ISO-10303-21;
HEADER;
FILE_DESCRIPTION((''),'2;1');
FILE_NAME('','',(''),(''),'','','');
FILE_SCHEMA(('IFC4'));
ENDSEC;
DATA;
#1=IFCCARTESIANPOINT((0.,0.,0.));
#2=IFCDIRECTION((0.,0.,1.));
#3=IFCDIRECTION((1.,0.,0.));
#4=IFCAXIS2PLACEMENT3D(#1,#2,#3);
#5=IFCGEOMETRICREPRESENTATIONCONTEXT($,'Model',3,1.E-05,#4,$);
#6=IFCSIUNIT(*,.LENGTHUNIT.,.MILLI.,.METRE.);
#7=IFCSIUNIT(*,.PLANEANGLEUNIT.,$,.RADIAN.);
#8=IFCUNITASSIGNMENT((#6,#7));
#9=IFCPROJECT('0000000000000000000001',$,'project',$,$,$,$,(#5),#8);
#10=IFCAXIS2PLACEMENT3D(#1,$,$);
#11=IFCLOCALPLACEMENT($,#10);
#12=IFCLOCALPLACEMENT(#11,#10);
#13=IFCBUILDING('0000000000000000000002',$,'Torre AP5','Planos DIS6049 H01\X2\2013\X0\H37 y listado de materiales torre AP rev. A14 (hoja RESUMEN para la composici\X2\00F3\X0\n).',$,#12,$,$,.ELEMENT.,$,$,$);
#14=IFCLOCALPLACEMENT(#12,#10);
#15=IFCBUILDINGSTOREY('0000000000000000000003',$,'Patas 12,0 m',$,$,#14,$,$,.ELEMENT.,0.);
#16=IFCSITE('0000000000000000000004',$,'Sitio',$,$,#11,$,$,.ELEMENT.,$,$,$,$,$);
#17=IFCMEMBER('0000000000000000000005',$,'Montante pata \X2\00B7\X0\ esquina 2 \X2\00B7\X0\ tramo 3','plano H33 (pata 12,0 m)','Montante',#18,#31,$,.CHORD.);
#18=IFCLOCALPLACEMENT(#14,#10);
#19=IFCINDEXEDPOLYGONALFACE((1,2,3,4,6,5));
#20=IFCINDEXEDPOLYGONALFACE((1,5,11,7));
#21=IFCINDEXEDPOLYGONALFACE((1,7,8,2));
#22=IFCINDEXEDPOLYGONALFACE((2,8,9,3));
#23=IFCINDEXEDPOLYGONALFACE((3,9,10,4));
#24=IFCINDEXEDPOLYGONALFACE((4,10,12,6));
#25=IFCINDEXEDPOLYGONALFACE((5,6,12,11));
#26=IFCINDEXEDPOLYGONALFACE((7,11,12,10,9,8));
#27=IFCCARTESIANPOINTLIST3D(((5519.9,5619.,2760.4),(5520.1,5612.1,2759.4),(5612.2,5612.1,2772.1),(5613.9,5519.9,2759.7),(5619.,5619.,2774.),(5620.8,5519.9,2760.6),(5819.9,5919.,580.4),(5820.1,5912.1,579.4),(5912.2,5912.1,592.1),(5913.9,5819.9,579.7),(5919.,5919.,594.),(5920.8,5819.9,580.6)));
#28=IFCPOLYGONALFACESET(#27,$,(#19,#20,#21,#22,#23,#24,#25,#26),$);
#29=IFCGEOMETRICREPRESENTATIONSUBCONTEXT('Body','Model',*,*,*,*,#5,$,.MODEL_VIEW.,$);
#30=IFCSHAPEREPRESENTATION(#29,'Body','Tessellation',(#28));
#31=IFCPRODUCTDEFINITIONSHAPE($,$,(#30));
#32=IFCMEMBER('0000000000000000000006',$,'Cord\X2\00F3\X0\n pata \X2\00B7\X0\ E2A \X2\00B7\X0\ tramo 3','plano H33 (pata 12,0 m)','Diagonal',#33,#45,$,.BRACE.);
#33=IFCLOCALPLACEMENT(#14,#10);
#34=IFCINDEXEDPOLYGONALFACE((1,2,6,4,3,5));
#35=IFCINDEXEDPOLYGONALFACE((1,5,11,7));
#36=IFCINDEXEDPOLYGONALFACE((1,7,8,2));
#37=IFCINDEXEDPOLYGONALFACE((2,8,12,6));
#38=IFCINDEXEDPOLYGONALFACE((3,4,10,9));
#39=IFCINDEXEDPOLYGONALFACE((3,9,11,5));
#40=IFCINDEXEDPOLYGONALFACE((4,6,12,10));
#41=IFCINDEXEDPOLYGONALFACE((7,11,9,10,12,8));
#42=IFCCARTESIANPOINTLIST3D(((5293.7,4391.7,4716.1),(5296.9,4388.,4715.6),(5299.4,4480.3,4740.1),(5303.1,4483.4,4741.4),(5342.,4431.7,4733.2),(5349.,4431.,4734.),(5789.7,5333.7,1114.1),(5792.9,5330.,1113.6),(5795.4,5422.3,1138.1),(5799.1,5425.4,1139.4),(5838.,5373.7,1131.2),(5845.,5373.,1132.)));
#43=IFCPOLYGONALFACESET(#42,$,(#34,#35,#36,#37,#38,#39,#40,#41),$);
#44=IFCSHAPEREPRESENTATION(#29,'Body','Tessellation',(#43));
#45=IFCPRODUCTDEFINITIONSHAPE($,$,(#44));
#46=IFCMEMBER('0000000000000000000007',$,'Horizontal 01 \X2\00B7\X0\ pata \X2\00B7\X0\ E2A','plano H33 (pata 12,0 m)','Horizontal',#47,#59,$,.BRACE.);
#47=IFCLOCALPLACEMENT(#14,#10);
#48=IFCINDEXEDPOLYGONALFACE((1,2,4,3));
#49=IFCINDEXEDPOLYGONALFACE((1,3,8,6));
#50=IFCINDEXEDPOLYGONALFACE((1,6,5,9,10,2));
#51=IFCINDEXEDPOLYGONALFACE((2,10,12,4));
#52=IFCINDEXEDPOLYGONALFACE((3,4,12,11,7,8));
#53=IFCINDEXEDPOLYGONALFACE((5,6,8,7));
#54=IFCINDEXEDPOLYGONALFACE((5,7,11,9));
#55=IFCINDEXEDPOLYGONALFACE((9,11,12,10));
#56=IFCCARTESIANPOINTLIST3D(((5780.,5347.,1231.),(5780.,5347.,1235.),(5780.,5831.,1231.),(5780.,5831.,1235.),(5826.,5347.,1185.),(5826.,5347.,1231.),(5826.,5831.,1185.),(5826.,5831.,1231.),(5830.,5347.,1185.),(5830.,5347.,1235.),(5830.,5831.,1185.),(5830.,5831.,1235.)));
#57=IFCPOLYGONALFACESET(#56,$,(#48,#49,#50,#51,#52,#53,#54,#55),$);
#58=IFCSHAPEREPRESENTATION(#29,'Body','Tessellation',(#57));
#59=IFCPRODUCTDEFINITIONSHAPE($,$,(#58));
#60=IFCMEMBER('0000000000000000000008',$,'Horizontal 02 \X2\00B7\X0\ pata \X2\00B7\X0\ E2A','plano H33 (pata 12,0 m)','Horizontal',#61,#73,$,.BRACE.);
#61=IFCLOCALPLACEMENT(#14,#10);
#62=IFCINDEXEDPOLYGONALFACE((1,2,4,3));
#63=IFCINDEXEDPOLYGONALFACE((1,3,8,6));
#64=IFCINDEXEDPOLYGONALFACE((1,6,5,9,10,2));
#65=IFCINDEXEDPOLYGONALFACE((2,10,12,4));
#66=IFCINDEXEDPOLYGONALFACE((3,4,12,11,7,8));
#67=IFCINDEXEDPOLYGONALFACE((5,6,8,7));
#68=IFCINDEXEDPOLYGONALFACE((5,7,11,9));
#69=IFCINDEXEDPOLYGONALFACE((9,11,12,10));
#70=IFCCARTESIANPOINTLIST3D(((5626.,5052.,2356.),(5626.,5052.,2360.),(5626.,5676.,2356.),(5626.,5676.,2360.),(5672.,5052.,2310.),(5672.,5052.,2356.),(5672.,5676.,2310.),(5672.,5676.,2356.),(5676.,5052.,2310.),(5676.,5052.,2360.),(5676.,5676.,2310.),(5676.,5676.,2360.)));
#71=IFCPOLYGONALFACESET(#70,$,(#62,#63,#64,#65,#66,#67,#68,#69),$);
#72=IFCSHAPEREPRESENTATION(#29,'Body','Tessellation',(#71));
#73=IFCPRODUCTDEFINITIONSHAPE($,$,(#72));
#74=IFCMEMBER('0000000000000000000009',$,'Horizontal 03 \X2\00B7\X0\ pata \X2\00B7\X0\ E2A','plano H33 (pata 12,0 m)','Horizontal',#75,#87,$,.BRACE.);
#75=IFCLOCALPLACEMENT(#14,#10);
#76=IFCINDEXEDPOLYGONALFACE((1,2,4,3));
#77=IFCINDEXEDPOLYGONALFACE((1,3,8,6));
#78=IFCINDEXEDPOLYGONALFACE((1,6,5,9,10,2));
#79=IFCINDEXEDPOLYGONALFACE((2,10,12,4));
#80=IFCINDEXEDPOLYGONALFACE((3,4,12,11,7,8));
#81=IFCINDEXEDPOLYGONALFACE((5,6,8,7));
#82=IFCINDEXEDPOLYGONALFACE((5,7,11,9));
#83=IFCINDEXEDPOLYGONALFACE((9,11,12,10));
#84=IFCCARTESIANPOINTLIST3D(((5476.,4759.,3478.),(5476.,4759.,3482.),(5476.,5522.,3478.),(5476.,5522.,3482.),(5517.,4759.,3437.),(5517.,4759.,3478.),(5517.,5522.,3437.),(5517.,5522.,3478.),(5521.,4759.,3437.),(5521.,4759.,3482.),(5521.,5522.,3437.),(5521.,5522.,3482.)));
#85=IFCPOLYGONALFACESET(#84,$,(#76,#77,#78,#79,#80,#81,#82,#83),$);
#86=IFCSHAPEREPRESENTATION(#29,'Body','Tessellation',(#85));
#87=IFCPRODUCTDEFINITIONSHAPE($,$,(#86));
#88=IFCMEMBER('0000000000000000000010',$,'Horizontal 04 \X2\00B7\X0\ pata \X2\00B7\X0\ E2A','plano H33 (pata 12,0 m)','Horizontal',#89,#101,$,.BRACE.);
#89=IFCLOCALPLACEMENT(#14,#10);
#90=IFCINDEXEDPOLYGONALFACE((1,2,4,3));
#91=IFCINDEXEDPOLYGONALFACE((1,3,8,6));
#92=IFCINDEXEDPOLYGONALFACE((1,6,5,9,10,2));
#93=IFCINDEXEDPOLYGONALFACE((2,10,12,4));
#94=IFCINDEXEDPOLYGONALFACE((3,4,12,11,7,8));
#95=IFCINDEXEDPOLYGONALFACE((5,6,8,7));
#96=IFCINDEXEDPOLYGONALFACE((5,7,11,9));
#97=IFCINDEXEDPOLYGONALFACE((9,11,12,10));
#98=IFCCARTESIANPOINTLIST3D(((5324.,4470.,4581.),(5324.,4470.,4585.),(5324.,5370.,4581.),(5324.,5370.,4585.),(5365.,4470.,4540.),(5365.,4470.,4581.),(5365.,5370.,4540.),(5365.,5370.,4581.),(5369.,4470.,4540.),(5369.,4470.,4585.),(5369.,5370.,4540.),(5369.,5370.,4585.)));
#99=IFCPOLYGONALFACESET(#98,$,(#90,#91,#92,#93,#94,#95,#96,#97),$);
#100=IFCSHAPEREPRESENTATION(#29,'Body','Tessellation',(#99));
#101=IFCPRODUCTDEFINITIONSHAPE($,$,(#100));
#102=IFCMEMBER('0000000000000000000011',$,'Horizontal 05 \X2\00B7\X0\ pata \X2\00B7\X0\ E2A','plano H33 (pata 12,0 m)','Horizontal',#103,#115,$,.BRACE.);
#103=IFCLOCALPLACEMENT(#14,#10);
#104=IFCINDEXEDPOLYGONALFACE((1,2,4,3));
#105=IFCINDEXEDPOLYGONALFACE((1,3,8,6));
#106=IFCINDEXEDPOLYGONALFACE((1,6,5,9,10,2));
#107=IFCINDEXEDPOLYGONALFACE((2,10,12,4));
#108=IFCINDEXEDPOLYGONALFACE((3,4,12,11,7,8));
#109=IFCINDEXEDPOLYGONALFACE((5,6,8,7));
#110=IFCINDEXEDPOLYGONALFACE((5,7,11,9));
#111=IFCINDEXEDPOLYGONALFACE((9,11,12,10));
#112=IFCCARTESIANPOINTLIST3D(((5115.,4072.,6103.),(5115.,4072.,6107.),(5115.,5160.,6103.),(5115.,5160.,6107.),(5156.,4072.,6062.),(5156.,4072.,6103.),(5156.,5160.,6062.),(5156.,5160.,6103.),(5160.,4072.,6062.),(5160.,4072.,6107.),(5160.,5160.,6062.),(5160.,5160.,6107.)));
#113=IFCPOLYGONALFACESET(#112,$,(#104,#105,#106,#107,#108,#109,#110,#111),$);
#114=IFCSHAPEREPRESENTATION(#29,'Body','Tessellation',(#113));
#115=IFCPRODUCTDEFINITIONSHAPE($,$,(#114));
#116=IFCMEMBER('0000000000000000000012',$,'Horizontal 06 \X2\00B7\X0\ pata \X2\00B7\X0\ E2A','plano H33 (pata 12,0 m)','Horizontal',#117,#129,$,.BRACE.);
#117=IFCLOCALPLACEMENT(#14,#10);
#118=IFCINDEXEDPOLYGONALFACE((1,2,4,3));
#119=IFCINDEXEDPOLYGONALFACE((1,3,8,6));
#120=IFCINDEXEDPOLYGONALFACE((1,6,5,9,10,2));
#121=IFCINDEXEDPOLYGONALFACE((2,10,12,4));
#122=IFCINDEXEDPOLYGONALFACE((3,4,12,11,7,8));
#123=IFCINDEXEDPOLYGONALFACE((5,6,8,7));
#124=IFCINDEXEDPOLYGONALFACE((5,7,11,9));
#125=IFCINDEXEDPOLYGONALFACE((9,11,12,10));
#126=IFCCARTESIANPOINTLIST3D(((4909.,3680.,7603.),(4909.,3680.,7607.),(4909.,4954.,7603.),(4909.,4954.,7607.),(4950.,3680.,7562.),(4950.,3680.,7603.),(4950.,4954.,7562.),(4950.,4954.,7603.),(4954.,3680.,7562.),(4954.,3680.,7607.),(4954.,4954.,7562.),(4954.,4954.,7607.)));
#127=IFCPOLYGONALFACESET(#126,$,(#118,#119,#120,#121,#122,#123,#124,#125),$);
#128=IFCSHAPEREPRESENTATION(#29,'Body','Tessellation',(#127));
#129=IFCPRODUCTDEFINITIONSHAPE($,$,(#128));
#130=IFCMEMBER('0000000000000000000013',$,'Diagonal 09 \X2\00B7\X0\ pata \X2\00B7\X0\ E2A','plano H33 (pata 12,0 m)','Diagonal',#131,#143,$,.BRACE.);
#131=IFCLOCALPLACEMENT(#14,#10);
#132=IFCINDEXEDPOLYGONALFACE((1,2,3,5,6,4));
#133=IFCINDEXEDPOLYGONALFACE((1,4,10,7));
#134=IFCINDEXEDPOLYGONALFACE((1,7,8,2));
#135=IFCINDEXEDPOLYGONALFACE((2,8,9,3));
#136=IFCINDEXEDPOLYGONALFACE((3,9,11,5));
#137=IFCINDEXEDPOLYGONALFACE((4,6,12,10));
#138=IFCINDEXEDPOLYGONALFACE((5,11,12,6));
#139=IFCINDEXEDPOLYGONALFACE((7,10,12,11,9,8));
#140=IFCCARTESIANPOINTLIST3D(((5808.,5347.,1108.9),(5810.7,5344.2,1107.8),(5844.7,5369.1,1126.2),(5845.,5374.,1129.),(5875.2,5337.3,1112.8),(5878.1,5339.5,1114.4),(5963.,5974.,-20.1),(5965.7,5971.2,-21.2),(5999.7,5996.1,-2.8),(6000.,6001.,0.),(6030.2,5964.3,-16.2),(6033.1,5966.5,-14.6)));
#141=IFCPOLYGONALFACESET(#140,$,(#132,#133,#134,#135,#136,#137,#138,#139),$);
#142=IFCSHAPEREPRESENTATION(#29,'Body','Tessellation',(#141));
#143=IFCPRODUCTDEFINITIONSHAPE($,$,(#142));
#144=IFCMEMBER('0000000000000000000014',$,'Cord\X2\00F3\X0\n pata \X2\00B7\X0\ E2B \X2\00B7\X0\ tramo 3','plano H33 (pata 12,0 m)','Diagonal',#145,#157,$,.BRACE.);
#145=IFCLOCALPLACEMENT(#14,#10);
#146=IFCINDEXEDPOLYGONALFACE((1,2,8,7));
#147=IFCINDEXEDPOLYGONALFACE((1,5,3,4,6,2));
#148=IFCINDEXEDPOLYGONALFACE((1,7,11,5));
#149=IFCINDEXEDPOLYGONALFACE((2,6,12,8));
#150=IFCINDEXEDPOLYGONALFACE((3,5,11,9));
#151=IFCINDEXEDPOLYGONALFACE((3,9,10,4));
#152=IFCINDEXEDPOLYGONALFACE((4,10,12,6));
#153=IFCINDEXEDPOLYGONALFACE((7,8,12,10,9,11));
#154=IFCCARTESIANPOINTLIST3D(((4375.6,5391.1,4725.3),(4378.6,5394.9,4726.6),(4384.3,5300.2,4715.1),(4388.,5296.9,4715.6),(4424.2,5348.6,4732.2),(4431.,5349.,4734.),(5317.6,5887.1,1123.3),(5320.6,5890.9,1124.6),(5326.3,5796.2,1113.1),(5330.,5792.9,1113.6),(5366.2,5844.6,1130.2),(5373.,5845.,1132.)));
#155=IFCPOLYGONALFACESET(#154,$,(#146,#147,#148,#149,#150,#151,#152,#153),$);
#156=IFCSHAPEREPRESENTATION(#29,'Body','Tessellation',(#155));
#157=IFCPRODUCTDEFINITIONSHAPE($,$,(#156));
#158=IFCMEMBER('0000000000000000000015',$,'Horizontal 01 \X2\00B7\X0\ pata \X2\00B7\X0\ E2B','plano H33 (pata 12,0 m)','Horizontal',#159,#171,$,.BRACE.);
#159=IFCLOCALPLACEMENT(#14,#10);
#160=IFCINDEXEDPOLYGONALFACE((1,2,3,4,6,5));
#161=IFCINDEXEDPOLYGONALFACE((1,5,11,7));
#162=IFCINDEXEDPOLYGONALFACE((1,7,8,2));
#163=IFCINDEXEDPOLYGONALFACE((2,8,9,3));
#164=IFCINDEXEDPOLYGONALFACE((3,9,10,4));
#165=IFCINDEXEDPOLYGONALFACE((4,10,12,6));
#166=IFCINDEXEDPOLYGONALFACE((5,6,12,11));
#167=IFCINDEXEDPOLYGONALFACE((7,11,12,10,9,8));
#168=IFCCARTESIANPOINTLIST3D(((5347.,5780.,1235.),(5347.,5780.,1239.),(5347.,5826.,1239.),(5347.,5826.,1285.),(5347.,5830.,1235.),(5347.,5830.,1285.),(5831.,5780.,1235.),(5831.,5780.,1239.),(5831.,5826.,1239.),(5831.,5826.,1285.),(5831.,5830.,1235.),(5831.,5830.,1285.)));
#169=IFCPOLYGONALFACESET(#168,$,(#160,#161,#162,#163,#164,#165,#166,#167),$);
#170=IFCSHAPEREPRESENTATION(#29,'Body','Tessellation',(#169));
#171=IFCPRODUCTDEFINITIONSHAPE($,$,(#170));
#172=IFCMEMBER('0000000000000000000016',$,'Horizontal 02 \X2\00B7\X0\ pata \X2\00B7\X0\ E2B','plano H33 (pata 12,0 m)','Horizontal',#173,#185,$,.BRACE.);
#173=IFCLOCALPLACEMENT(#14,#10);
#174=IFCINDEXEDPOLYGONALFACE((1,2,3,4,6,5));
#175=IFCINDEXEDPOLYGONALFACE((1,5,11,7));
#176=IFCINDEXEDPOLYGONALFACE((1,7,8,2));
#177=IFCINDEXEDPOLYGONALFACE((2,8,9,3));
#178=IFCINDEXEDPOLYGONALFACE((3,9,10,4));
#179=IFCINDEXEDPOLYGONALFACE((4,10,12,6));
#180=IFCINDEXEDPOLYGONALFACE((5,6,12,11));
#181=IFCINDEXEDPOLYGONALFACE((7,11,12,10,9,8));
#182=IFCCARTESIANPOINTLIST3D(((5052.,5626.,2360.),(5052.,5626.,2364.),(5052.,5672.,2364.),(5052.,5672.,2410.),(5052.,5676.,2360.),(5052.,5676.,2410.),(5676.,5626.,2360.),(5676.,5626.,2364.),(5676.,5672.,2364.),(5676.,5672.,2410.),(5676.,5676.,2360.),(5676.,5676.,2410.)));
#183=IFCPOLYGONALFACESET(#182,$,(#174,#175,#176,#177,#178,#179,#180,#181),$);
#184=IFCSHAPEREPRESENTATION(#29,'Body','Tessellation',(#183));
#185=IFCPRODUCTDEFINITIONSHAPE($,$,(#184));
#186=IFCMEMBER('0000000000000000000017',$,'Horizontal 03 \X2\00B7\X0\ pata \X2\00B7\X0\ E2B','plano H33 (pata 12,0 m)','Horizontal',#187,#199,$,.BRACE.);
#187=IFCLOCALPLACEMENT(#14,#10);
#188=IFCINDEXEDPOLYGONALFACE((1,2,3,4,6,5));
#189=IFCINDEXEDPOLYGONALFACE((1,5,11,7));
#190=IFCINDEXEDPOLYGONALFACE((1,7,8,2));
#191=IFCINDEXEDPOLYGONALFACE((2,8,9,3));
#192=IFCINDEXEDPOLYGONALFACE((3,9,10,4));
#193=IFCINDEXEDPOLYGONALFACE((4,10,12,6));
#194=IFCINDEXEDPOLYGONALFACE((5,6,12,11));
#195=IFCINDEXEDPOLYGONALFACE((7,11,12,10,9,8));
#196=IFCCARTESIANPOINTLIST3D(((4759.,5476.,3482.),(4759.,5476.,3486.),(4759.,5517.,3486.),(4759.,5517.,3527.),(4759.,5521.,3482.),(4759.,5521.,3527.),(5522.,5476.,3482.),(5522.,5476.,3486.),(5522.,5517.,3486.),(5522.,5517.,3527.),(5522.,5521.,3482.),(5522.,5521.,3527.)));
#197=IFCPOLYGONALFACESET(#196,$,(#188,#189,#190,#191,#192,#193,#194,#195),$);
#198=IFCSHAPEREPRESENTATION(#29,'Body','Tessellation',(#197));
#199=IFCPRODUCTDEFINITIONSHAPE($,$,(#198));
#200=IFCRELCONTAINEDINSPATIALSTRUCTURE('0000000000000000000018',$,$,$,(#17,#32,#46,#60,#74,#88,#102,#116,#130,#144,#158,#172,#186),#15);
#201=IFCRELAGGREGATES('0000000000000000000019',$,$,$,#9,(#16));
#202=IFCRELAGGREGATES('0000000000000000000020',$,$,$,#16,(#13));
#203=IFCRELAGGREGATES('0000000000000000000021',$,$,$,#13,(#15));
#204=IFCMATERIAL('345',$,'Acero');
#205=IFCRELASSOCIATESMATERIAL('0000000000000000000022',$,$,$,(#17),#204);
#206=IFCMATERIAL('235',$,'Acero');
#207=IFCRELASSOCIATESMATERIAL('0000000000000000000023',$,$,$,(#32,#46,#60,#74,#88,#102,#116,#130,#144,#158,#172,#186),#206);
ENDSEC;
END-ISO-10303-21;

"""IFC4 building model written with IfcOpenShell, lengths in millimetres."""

from ifc_helpers import new_model, si_unit, frame, frame_2d, origin, origin_with_axes, place, context, subcontext, project, spatial, l_section, extrude, material, element, save


model = new_model("IFC4")

# Units and contexts
model_context = context("Model", 3, precision=1e-05, world=origin_with_axes())
body_context = subcontext(model_context, "Body", "Model", "MODEL_VIEW")
ifc_project = project(units=[si_unit("LENGTHUNIT", "METRE", prefix="MILLI"), si_unit("PLANEANGLEUNIT", "RADIAN")], contexts=[model_context])

# Site, building, storey
site_placement = place(None, origin())
site = spatial("IfcSite", under=ifc_project, at=site_placement, Name="Sitio", CompositionType="ELEMENT")
building_placement = place(site_placement, origin())
building = spatial("IfcBuilding", under=site, at=building_placement, Name="Torre AP5", Description="Planos DIS6049 H01–H37 y listado de materiales torre AP rev. A14 (hoja RESUMEN para la composición).", CompositionType="ELEMENT")
storey_placement = place(building_placement, origin())
storey = spatial("IfcBuildingStorey", under=building, at=storey_placement, Name="Patas 12,0 m", CompositionType="ELEMENT", Elevation=0.0)

# Members
ifc_material_1 = material(Name="345", Category="Acero")
member_1_placement = place(storey_placement, frame((5619.0, 5619.0, 2774.0), z_axis=(0.13508, 0.13508, -0.981584), x_axis=(0.018415, -0.990835, -0.133819)))
element("IfcMember", 1, at=member_1_placement, inside=storey, material=ifc_material_1, Name="Montante pata · esquina 2 · tramo 3", Description="plano H33 (pata 12,0 m)", ObjectType="Montante", PredefinedType="CHORD", context=body_context, shape_type="SweptSolid", body=[
    extrude(l_section(Depth=100.0, Width=100.0, Thickness=7.0, at=frame_2d((50.0, 50.0))), None, (0.0, 0.0, 1.0), 2220.9),
])
ifc_material_2 = material(Name="235", Category="Acero")
member_2_placement = place(storey_placement, frame((5349.0, 4431.0, 4734.0), z_axis=(0.132054, 0.250797, -0.958991), x_axis=(-0.743837, -0.614396, -0.263105)))
element("IfcMember", 2, at=member_2_placement, inside=storey, material=ifc_material_2, Name="Cordón pata · E2A · tramo 3", Description="plano H33 (pata 12,0 m)", ObjectType="Diagonal", PredefinedType="BRACE", context=body_context, shape_type="SweptSolid", body=[
    extrude(l_section(Depth=70.0, Width=70.0, Thickness=5.0, at=frame_2d((35.0, 35.0))), None, (0.0, 0.0, 1.0), 3756.0),
])
member_3_placement = place(storey_placement, frame((5830.0, 5831.0, 1235.0), z_axis=(0.0, -1.0, 0.0), x_axis=(-1.0, 0.0, 0.0)))
element("IfcMember", 3, at=member_3_placement, inside=storey, material=ifc_material_2, Name="Horizontal 01 · pata · E2A", Description="plano H33 (pata 12,0 m)", ObjectType="Horizontal", PredefinedType="BRACE", context=body_context, shape_type="SweptSolid", body=[
    extrude(l_section(Depth=50.0, Width=50.0, Thickness=4.0, at=frame_2d((25.0, 25.0))), None, (0.0, 0.0, 1.0), 484.0),
])
member_4_placement = place(storey_placement, frame((5676.0, 5676.0, 2360.0), z_axis=(0.0, -1.0, 0.0), x_axis=(-1.0, 0.0, 0.0)))
element("IfcMember", 4, at=member_4_placement, inside=storey, material=ifc_material_2, Name="Horizontal 02 · pata · E2A", Description="plano H33 (pata 12,0 m)", ObjectType="Horizontal", PredefinedType="BRACE", context=body_context, shape_type="SweptSolid", body=[
    extrude(l_section(Depth=50.0, Width=50.0, Thickness=4.0, at=frame_2d((25.0, 25.0))), None, (0.0, 0.0, 1.0), 624.0),
])
member_5_placement = place(storey_placement, frame((5521.0, 5522.0, 3482.0), z_axis=(0.0, -1.0, 0.0), x_axis=(-1.0, 0.0, 0.0)))
element("IfcMember", 5, at=member_5_placement, inside=storey, material=ifc_material_2, Name="Horizontal 03 · pata · E2A", Description="plano H33 (pata 12,0 m)", ObjectType="Horizontal", PredefinedType="BRACE", context=body_context, shape_type="SweptSolid", body=[
    extrude(l_section(Depth=45.0, Width=45.0, Thickness=4.0, at=frame_2d((22.5, 22.5))), None, (0.0, 0.0, 1.0), 763.0),
])
member_6_placement = place(storey_placement, frame((5369.0, 5370.0, 4585.0), z_axis=(0.0, -1.0, 0.0), x_axis=(-1.0, 0.0, 0.0)))
element("IfcMember", 6, at=member_6_placement, inside=storey, material=ifc_material_2, Name="Horizontal 04 · pata · E2A", Description="plano H33 (pata 12,0 m)", ObjectType="Horizontal", PredefinedType="BRACE", context=body_context, shape_type="SweptSolid", body=[
    extrude(l_section(Depth=45.0, Width=45.0, Thickness=4.0, at=frame_2d((22.5, 22.5))), None, (0.0, 0.0, 1.0), 900.0),
])
member_7_placement = place(storey_placement, frame((5160.0, 5160.0, 6107.0), z_axis=(0.0, -1.0, 0.0), x_axis=(-1.0, 0.0, 0.0)))
element("IfcMember", 7, at=member_7_placement, inside=storey, material=ifc_material_2, Name="Horizontal 05 · pata · E2A", Description="plano H33 (pata 12,0 m)", ObjectType="Horizontal", PredefinedType="BRACE", context=body_context, shape_type="SweptSolid", body=[
    extrude(l_section(Depth=45.0, Width=45.0, Thickness=4.0, at=frame_2d((22.5, 22.5))), None, (0.0, 0.0, 1.0), 1088.0),
])
member_8_placement = place(storey_placement, frame((4954.0, 4954.0, 7607.0), z_axis=(0.0, -1.0, 0.0), x_axis=(-1.0, 0.0, 0.0)))
element("IfcMember", 8, at=member_8_placement, inside=storey, material=ifc_material_2, Name="Horizontal 06 · pata · E2A", Description="plano H33 (pata 12,0 m)", ObjectType="Horizontal", PredefinedType="BRACE", context=body_context, shape_type="SweptSolid", body=[
    extrude(l_section(Depth=45.0, Width=45.0, Thickness=4.0, at=frame_2d((22.5, 22.5))), None, (0.0, 0.0, 1.0), 1274.0),
])
member_9_placement = place(storey_placement, frame((6000.0, 6001.0, 0.0), z_axis=(-0.119168, -0.482052, 0.868001), x_axis=(-0.73958, -0.54018, -0.40153)))
element("IfcMember", 9, at=member_9_placement, inside=storey, material=ifc_material_2, Name="Diagonal 09 · pata · E2A", Description="plano H33 (pata 12,0 m)", ObjectType="Diagonal", PredefinedType="BRACE", context=body_context, shape_type="SweptSolid", body=[
    extrude(l_section(Depth=50.0, Width=50.0, Thickness=4.0, at=frame_2d((25.0, 25.0))), None, (0.0, 0.0, 1.0), 1300.7),
])
member_10_placement = place(storey_placement, frame((4431.0, 5349.0, 4734.0), z_axis=(0.250797, 0.132054, -0.958991), x_axis=(-0.614396, -0.743837, -0.263105)))
element("IfcMember", 10, at=member_10_placement, inside=storey, material=ifc_material_2, Name="Cordón pata · E2B · tramo 3", Description="plano H33 (pata 12,0 m)", ObjectType="Diagonal", PredefinedType="BRACE", context=body_context, shape_type="SweptSolid", body=[
    extrude(l_section(Depth=70.0, Width=70.0, Thickness=5.0, at=frame_2d((35.0, 35.0))), None, (0.0, 0.0, 1.0), 3756.0),
])
member_11_placement = place(storey_placement, frame((5831.0, 5830.0, 1235.0), z_axis=(-1.0, 0.0, 0.0), x_axis=(0.0, -1.0, 0.0)))
element("IfcMember", 11, at=member_11_placement, inside=storey, material=ifc_material_2, Name="Horizontal 01 · pata · E2B", Description="plano H33 (pata 12,0 m)", ObjectType="Horizontal", PredefinedType="BRACE", context=body_context, shape_type="SweptSolid", body=[
    extrude(l_section(Depth=50.0, Width=50.0, Thickness=4.0, at=frame_2d((25.0, 25.0))), None, (0.0, 0.0, 1.0), 484.0),
])
member_12_placement = place(storey_placement, frame((5676.0, 5676.0, 2360.0), z_axis=(-1.0, 0.0, 0.0), x_axis=(0.0, -1.0, 0.0)))
element("IfcMember", 12, at=member_12_placement, inside=storey, material=ifc_material_2, Name="Horizontal 02 · pata · E2B", Description="plano H33 (pata 12,0 m)", ObjectType="Horizontal", PredefinedType="BRACE", context=body_context, shape_type="SweptSolid", body=[
    extrude(l_section(Depth=50.0, Width=50.0, Thickness=4.0, at=frame_2d((25.0, 25.0))), None, (0.0, 0.0, 1.0), 624.0),
])
member_13_placement = place(storey_placement, frame((5522.0, 5521.0, 3482.0), z_axis=(-1.0, 0.0, 0.0), x_axis=(0.0, -1.0, 0.0)))
element("IfcMember", 13, at=member_13_placement, inside=storey, material=ifc_material_2, Name="Horizontal 03 · pata · E2B", Description="plano H33 (pata 12,0 m)", ObjectType="Horizontal", PredefinedType="BRACE", context=body_context, shape_type="SweptSolid", body=[
    extrude(l_section(Depth=45.0, Width=45.0, Thickness=4.0, at=frame_2d((22.5, 22.5))), None, (0.0, 0.0, 1.0), 763.0),
])

save(model, "model.ifc")
